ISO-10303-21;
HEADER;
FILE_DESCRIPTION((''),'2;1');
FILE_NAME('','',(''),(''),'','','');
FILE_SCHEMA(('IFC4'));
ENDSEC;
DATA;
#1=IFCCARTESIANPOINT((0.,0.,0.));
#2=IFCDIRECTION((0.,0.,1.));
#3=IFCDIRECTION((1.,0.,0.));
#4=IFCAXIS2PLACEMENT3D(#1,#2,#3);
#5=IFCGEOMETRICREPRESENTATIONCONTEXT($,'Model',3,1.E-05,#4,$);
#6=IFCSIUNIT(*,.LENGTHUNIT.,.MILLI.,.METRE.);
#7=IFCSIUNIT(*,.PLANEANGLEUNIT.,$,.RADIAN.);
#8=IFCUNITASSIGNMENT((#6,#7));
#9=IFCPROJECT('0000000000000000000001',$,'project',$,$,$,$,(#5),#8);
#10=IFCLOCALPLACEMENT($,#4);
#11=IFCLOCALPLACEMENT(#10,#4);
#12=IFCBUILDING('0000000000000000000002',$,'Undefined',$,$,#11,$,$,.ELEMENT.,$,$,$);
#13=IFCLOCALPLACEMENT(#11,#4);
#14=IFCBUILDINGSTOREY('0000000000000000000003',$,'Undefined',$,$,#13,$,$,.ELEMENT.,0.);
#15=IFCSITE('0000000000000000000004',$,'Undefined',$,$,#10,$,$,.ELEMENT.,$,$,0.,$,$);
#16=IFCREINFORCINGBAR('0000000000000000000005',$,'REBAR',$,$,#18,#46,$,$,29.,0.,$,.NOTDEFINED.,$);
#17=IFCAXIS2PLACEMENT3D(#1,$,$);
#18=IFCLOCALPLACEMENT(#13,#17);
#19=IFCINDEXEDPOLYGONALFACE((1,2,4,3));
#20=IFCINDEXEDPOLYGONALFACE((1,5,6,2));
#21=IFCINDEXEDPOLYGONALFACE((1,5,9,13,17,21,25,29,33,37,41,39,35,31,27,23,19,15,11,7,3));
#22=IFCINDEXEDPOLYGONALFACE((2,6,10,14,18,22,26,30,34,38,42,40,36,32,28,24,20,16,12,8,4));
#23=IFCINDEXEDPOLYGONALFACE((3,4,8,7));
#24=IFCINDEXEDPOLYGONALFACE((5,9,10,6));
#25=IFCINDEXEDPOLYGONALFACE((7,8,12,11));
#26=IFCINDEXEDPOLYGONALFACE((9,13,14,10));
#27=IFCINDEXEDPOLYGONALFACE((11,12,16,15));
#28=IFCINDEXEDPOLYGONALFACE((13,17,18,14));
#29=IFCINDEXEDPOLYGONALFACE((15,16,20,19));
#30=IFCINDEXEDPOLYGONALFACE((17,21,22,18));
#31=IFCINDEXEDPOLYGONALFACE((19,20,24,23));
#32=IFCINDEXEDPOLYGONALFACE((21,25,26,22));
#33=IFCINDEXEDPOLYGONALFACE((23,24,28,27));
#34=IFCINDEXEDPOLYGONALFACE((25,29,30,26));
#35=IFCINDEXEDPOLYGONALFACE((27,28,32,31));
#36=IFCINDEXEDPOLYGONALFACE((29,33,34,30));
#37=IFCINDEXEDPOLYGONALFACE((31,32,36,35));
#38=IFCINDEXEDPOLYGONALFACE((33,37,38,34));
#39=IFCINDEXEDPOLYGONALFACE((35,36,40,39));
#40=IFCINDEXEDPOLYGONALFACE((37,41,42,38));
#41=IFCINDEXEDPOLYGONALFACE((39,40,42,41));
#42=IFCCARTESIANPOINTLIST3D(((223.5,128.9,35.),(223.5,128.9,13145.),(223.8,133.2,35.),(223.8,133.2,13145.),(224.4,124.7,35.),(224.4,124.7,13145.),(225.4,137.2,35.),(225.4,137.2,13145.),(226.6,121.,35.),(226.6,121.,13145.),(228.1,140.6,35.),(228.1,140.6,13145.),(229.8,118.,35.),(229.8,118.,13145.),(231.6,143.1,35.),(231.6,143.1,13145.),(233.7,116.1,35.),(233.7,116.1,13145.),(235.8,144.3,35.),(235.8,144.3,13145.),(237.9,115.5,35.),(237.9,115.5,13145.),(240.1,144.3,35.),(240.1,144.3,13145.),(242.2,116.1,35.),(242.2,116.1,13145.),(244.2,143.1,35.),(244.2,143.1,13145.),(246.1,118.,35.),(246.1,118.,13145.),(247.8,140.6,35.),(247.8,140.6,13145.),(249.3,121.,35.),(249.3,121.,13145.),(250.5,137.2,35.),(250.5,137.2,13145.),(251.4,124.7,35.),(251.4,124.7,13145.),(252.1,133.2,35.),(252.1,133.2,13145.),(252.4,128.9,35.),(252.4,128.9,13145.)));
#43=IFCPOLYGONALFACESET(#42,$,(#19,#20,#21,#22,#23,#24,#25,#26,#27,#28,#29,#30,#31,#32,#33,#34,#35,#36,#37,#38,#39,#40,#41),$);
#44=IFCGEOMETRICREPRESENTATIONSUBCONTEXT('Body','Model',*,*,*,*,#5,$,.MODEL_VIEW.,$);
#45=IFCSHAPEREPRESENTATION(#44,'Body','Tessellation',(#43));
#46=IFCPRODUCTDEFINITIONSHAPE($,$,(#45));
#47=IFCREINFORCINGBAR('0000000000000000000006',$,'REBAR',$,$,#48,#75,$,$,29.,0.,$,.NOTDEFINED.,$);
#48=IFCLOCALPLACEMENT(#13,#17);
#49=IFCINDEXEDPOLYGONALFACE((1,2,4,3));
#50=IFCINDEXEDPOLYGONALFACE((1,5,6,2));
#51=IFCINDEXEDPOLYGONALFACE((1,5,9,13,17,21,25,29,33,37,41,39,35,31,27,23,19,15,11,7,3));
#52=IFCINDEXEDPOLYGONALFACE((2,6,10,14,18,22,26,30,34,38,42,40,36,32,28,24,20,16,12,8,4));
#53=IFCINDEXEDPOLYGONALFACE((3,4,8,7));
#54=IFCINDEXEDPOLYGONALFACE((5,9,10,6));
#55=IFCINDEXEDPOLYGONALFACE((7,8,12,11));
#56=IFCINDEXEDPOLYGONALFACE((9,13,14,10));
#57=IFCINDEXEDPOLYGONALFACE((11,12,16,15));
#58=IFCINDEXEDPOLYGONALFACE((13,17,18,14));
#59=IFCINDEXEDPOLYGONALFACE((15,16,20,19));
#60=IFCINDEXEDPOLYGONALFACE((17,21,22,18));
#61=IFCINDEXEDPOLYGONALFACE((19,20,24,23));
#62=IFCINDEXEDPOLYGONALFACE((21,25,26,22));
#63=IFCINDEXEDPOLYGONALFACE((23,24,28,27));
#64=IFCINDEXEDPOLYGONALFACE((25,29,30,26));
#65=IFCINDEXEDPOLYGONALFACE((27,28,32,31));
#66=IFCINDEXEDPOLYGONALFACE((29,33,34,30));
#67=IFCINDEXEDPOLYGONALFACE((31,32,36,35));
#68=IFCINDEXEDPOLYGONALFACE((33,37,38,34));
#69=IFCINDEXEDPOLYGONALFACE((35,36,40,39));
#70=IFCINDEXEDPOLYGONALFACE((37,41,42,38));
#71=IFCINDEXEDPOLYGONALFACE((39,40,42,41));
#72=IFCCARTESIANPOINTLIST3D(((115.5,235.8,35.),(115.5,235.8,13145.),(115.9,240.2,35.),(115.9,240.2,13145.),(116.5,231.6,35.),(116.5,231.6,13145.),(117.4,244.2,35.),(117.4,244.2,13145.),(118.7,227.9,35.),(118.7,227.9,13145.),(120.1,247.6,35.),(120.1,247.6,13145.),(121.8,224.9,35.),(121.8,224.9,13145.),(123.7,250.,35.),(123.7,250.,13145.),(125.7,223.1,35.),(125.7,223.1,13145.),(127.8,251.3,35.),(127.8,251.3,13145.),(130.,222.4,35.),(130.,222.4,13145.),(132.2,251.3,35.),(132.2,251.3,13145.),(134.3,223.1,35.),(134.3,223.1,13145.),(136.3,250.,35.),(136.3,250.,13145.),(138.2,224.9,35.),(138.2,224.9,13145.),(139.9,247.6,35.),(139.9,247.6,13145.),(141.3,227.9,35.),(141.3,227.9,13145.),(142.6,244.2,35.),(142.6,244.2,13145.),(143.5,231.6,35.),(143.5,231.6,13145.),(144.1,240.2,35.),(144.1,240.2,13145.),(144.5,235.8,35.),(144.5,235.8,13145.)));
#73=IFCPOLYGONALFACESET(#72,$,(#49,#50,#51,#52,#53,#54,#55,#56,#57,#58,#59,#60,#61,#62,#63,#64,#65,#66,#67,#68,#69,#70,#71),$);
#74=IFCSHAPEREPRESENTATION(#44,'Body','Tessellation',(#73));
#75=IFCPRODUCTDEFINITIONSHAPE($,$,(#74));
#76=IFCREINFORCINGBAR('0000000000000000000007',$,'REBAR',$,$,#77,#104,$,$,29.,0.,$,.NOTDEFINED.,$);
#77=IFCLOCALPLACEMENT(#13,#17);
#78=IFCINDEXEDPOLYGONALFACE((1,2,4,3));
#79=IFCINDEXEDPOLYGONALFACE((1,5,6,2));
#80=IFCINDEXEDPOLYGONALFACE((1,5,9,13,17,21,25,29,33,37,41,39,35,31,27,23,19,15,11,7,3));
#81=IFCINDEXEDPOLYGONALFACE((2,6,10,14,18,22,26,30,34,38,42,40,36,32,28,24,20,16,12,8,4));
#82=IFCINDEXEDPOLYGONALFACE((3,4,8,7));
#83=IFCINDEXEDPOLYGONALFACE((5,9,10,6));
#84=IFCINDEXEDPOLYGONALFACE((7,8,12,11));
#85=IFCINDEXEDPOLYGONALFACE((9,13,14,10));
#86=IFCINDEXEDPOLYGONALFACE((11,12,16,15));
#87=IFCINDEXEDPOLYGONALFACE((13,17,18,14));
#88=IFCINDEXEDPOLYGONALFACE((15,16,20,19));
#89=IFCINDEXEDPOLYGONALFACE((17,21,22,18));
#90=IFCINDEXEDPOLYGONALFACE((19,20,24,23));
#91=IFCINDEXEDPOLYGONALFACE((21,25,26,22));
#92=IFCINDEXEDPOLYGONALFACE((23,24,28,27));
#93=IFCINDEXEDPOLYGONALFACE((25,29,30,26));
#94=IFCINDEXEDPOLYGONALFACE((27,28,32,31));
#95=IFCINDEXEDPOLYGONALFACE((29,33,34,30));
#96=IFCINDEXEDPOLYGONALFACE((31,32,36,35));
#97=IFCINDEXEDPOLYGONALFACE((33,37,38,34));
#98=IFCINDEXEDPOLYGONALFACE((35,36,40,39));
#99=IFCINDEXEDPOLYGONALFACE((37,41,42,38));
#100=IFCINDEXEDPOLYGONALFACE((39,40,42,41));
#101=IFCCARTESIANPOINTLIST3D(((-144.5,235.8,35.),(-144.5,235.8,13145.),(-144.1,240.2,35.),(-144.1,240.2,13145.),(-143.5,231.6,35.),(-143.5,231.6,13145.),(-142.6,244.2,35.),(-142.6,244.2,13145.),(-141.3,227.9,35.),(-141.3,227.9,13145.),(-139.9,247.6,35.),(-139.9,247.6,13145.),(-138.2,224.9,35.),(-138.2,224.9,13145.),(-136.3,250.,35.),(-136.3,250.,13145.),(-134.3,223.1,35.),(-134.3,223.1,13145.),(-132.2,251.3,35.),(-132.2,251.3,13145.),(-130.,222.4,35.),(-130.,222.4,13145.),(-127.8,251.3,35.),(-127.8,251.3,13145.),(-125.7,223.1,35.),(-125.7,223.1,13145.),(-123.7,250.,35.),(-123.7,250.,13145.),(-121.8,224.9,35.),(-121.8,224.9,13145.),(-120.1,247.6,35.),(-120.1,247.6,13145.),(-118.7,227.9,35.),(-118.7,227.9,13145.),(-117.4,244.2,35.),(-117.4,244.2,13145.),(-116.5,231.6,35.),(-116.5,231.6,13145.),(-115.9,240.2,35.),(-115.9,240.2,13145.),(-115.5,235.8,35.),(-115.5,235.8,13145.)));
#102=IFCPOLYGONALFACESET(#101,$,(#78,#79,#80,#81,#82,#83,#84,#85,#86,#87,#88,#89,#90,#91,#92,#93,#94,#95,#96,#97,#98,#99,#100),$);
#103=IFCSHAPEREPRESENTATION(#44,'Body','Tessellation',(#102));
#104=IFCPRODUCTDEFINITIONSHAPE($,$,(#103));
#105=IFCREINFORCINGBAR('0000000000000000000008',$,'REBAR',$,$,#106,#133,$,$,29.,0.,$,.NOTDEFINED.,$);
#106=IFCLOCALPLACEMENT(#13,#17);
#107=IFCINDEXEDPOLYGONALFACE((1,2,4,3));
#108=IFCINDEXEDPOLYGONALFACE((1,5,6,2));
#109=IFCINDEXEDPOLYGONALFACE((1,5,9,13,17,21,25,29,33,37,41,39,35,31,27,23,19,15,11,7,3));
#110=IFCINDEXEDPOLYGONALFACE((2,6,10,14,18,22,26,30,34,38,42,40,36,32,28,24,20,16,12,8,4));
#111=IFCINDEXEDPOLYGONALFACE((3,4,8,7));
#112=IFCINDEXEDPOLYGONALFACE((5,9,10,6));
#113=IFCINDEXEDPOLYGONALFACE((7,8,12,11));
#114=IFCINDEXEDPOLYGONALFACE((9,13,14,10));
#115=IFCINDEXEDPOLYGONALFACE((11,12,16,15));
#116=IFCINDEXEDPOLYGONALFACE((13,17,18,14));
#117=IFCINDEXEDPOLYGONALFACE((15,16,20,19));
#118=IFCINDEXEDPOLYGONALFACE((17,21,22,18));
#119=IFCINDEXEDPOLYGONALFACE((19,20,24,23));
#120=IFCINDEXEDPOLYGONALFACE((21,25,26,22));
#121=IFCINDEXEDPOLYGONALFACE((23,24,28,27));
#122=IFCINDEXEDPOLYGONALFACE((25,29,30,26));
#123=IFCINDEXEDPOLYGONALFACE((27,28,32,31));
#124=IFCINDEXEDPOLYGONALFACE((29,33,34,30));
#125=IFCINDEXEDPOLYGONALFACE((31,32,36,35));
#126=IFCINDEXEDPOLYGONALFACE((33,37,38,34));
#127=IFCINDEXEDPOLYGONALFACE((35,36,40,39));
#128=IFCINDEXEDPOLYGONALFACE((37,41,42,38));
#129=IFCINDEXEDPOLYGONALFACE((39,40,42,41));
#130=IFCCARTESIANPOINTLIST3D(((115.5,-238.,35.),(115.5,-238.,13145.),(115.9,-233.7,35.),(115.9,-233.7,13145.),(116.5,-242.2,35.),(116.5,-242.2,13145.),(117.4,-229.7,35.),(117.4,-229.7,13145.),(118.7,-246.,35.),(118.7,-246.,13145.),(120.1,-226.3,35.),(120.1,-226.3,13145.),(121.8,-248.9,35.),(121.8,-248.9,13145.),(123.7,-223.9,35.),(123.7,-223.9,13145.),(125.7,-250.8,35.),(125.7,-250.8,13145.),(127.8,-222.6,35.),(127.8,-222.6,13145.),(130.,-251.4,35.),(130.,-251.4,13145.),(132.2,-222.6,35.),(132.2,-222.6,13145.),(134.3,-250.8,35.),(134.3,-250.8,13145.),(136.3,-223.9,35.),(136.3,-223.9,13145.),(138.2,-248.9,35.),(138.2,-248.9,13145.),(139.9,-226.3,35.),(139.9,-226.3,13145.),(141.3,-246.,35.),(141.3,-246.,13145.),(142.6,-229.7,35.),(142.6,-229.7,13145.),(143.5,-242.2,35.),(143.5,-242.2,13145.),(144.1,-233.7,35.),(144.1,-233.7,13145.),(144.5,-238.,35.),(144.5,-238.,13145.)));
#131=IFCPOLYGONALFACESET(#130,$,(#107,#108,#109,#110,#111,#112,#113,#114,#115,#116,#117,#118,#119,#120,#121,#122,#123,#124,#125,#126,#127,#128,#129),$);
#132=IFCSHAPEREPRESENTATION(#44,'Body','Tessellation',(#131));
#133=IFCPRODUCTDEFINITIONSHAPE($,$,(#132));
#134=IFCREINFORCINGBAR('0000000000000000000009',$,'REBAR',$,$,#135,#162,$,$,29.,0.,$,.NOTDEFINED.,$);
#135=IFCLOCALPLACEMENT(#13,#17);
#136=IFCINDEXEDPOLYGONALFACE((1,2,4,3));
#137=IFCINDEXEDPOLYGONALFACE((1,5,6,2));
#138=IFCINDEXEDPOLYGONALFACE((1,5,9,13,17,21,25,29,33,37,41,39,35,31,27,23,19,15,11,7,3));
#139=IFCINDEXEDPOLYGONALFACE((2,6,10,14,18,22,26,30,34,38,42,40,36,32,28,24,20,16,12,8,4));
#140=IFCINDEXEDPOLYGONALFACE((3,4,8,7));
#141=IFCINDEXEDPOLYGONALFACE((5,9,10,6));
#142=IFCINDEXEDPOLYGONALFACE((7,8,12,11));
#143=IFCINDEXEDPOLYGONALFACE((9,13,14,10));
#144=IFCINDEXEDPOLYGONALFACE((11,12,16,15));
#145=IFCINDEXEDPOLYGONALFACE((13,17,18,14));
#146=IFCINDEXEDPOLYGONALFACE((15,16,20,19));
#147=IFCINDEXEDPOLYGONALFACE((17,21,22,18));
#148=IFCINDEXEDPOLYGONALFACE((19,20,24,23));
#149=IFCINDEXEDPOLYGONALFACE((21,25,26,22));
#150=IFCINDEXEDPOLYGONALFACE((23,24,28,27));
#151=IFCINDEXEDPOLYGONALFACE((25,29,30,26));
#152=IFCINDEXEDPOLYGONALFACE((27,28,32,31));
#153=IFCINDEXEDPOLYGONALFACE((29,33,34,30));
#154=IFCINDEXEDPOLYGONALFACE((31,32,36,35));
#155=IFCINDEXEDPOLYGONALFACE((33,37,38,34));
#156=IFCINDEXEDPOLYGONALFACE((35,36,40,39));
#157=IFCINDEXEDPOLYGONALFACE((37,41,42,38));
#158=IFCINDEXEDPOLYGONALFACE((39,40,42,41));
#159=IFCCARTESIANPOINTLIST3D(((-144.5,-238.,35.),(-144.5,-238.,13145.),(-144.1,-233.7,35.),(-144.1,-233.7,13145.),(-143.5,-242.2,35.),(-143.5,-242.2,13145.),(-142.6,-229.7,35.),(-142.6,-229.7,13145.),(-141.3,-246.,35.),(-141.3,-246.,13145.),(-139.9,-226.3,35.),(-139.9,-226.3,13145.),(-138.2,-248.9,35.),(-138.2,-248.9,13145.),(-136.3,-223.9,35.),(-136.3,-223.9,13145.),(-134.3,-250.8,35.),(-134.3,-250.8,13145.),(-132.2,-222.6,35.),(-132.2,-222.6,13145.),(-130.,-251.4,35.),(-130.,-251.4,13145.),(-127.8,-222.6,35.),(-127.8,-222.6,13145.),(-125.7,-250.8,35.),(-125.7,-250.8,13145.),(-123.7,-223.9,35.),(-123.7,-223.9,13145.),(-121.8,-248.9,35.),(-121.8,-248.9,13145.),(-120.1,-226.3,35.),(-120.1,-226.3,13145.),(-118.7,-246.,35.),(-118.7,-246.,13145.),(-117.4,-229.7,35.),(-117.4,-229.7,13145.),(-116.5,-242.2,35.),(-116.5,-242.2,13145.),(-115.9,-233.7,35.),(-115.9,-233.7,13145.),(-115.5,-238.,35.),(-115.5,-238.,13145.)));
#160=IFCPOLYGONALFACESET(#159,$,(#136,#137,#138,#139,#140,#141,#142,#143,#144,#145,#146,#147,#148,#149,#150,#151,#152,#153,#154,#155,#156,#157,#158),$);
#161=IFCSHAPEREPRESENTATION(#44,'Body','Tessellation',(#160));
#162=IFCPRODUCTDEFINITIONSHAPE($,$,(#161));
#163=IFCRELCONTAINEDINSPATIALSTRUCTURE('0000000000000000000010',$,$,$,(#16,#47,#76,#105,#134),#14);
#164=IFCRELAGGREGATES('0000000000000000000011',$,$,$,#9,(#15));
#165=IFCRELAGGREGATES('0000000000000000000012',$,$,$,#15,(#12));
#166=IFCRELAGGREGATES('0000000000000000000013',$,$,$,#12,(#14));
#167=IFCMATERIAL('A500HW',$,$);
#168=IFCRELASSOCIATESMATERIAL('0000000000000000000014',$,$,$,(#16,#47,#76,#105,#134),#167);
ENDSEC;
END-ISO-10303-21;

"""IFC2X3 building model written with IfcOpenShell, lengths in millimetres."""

from ifc_helpers import new_model, entity, si_unit, frame, origin_with_axes, place, context, subcontext, project, spatial, source, transform, mapped, material, element, save


model = new_model("IFC2X3")

# Units and contexts
model_context = context("Model", 3, precision=1e-05, world=origin_with_axes())
body_context = subcontext(model_context, "Body", "Model", "MODEL_VIEW")
ifc_project = project(units=[si_unit("LENGTHUNIT", "METRE", prefix="MILLI"), si_unit("PLANEANGLEUNIT", "RADIAN")], contexts=[model_context])

# Site, building, storey
site_placement = place(None, origin_with_axes())
site = spatial("IfcSite", under=ifc_project, at=site_placement, Name="Undefined", CompositionType="ELEMENT", RefElevation=0.0)
building_placement = place(site_placement, origin_with_axes())
building = spatial("IfcBuilding", under=site, at=building_placement, Name="Undefined", CompositionType="ELEMENT")
storey_placement = place(building_placement, origin_with_axes())
storey = spatial("IfcBuildingStorey", under=building, at=storey_placement, Name="Undefined", CompositionType="ELEMENT", Elevation=0.0)

# Reinforcing bars
ifc_material_1 = material(Name="A500HW")
shared_shape_1 = source(origin_with_axes(), body_context, "Body", "AdvancedSweptSolid", [
    entity("IfcSweptDiskSolid", entity("IfcTrimmedCurve", entity("IfcLine", entity("IfcCartesianPoint", [0.0, 0.0, 0.0]), entity("IfcVector", entity("IfcDirection", [1.0, 0.0, 0.0]), 1.0)), [entity("IfcParameterValue", 0.0)], [entity("IfcParameterValue", 13110.03)], True, "PARAMETER"), 14.5, None, 0.0, 13110.0),
])
reinforcing_bar_1_placement = place(storey_placement, frame((237.9, 130.0, 125.0), z_axis=(0.0, -1.0, 0.0), x_axis=(0.0, 0.0, 1.0)))
element("IfcReinforcingBar", 1, at=reinforcing_bar_1_placement, inside=storey, material=ifc_material_1, Name="REBAR", BarRole="NOTDEFINED", CrossSectionArea=0.0, NominalDiameter=29.0, context=body_context, shape_type="MappedRepresentation", body=[
    mapped(shared_shape_1, transform((-90.0, 0.0, 0.0))),
])
shared_shape_2 = source(origin_with_axes(), body_context, "Body", "AdvancedSweptSolid", [
    entity("IfcSweptDiskSolid", entity("IfcTrimmedCurve", entity("IfcLine", entity("IfcCartesianPoint", [0.0, 0.0, 0.0]), entity("IfcVector", entity("IfcDirection", [1.0, 0.0, 0.0]), 1.0)), [entity("IfcParameterValue", 0.0)], [entity("IfcParameterValue", 13110.03)], True, "PARAMETER"), 14.5, None, 0.0, 13110.0),
])
reinforcing_bar_2_placement = place(storey_placement, frame((130.0, 236.9, 125.0), z_axis=(0.0, -1.0, 0.0), x_axis=(0.0, 0.0, 1.0)))
element("IfcReinforcingBar", 2, at=reinforcing_bar_2_placement, inside=storey, material=ifc_material_1, Name="REBAR", BarRole="NOTDEFINED", CrossSectionArea=0.0, NominalDiameter=29.0, context=body_context, shape_type="MappedRepresentation", body=[
    mapped(shared_shape_2, transform((-90.0, 0.0, 0.0))),
])
shared_shape_3 = source(origin_with_axes(), body_context, "Body", "AdvancedSweptSolid", [
    entity("IfcSweptDiskSolid", entity("IfcTrimmedCurve", entity("IfcLine", entity("IfcCartesianPoint", [0.0, 0.0, 0.0]), entity("IfcVector", entity("IfcDirection", [1.0, 0.0, 0.0]), 1.0)), [entity("IfcParameterValue", 0.0)], [entity("IfcParameterValue", 13110.03)], True, "PARAMETER"), 14.5, None, 0.0, 13110.0),
])
reinforcing_bar_3_placement = place(storey_placement, frame((-130.0, 236.9, 125.0), z_axis=(0.0, -1.0, 0.0), x_axis=(0.0, 0.0, 1.0)))
element("IfcReinforcingBar", 3, at=reinforcing_bar_3_placement, inside=storey, material=ifc_material_1, Name="REBAR", BarRole="NOTDEFINED", CrossSectionArea=0.0, NominalDiameter=29.0, context=body_context, shape_type="MappedRepresentation", body=[
    mapped(shared_shape_3, transform((-90.0, 0.0, 0.0))),
])
shared_shape_4 = source(origin_with_axes(), body_context, "Body", "AdvancedSweptSolid", [
    entity("IfcSweptDiskSolid", entity("IfcTrimmedCurve", entity("IfcLine", entity("IfcCartesianPoint", [0.0, 0.0, 0.0]), entity("IfcVector", entity("IfcDirection", [1.0, 0.0, 0.0]), 1.0)), [entity("IfcParameterValue", 0.0)], [entity("IfcParameterValue", 13110.03)], True, "PARAMETER"), 14.5, None, 0.0, 13110.0),
])
reinforcing_bar_4_placement = place(storey_placement, frame((130.0, -236.9, 125.0), z_axis=(0.0, -1.0, 0.0), x_axis=(0.0, 0.0, 1.0)))
element("IfcReinforcingBar", 4, at=reinforcing_bar_4_placement, inside=storey, material=ifc_material_1, Name="REBAR", BarRole="NOTDEFINED", CrossSectionArea=0.0, NominalDiameter=29.0, context=body_context, shape_type="MappedRepresentation", body=[
    mapped(shared_shape_4, transform((-90.0, 0.0, 0.0))),
])
shared_shape_5 = source(origin_with_axes(), body_context, "Body", "AdvancedSweptSolid", [
    entity("IfcSweptDiskSolid", entity("IfcTrimmedCurve", entity("IfcLine", entity("IfcCartesianPoint", [0.0, 0.0, 0.0]), entity("IfcVector", entity("IfcDirection", [1.0, 0.0, 0.0]), 1.0)), [entity("IfcParameterValue", 0.0)], [entity("IfcParameterValue", 13110.03)], True, "PARAMETER"), 14.5, None, 0.0, 13110.0),
])
reinforcing_bar_5_placement = place(storey_placement, frame((-130.0, -236.9, 125.0), z_axis=(0.0, -1.0, 0.0), x_axis=(0.0, 0.0, 1.0)))
element("IfcReinforcingBar", 5, at=reinforcing_bar_5_placement, inside=storey, material=ifc_material_1, Name="REBAR", BarRole="NOTDEFINED", CrossSectionArea=0.0, NominalDiameter=29.0, context=body_context, shape_type="MappedRepresentation", body=[
    mapped(shared_shape_5, transform((-90.0, 0.0, 0.0))),
])

save(model, "model.ifc")
